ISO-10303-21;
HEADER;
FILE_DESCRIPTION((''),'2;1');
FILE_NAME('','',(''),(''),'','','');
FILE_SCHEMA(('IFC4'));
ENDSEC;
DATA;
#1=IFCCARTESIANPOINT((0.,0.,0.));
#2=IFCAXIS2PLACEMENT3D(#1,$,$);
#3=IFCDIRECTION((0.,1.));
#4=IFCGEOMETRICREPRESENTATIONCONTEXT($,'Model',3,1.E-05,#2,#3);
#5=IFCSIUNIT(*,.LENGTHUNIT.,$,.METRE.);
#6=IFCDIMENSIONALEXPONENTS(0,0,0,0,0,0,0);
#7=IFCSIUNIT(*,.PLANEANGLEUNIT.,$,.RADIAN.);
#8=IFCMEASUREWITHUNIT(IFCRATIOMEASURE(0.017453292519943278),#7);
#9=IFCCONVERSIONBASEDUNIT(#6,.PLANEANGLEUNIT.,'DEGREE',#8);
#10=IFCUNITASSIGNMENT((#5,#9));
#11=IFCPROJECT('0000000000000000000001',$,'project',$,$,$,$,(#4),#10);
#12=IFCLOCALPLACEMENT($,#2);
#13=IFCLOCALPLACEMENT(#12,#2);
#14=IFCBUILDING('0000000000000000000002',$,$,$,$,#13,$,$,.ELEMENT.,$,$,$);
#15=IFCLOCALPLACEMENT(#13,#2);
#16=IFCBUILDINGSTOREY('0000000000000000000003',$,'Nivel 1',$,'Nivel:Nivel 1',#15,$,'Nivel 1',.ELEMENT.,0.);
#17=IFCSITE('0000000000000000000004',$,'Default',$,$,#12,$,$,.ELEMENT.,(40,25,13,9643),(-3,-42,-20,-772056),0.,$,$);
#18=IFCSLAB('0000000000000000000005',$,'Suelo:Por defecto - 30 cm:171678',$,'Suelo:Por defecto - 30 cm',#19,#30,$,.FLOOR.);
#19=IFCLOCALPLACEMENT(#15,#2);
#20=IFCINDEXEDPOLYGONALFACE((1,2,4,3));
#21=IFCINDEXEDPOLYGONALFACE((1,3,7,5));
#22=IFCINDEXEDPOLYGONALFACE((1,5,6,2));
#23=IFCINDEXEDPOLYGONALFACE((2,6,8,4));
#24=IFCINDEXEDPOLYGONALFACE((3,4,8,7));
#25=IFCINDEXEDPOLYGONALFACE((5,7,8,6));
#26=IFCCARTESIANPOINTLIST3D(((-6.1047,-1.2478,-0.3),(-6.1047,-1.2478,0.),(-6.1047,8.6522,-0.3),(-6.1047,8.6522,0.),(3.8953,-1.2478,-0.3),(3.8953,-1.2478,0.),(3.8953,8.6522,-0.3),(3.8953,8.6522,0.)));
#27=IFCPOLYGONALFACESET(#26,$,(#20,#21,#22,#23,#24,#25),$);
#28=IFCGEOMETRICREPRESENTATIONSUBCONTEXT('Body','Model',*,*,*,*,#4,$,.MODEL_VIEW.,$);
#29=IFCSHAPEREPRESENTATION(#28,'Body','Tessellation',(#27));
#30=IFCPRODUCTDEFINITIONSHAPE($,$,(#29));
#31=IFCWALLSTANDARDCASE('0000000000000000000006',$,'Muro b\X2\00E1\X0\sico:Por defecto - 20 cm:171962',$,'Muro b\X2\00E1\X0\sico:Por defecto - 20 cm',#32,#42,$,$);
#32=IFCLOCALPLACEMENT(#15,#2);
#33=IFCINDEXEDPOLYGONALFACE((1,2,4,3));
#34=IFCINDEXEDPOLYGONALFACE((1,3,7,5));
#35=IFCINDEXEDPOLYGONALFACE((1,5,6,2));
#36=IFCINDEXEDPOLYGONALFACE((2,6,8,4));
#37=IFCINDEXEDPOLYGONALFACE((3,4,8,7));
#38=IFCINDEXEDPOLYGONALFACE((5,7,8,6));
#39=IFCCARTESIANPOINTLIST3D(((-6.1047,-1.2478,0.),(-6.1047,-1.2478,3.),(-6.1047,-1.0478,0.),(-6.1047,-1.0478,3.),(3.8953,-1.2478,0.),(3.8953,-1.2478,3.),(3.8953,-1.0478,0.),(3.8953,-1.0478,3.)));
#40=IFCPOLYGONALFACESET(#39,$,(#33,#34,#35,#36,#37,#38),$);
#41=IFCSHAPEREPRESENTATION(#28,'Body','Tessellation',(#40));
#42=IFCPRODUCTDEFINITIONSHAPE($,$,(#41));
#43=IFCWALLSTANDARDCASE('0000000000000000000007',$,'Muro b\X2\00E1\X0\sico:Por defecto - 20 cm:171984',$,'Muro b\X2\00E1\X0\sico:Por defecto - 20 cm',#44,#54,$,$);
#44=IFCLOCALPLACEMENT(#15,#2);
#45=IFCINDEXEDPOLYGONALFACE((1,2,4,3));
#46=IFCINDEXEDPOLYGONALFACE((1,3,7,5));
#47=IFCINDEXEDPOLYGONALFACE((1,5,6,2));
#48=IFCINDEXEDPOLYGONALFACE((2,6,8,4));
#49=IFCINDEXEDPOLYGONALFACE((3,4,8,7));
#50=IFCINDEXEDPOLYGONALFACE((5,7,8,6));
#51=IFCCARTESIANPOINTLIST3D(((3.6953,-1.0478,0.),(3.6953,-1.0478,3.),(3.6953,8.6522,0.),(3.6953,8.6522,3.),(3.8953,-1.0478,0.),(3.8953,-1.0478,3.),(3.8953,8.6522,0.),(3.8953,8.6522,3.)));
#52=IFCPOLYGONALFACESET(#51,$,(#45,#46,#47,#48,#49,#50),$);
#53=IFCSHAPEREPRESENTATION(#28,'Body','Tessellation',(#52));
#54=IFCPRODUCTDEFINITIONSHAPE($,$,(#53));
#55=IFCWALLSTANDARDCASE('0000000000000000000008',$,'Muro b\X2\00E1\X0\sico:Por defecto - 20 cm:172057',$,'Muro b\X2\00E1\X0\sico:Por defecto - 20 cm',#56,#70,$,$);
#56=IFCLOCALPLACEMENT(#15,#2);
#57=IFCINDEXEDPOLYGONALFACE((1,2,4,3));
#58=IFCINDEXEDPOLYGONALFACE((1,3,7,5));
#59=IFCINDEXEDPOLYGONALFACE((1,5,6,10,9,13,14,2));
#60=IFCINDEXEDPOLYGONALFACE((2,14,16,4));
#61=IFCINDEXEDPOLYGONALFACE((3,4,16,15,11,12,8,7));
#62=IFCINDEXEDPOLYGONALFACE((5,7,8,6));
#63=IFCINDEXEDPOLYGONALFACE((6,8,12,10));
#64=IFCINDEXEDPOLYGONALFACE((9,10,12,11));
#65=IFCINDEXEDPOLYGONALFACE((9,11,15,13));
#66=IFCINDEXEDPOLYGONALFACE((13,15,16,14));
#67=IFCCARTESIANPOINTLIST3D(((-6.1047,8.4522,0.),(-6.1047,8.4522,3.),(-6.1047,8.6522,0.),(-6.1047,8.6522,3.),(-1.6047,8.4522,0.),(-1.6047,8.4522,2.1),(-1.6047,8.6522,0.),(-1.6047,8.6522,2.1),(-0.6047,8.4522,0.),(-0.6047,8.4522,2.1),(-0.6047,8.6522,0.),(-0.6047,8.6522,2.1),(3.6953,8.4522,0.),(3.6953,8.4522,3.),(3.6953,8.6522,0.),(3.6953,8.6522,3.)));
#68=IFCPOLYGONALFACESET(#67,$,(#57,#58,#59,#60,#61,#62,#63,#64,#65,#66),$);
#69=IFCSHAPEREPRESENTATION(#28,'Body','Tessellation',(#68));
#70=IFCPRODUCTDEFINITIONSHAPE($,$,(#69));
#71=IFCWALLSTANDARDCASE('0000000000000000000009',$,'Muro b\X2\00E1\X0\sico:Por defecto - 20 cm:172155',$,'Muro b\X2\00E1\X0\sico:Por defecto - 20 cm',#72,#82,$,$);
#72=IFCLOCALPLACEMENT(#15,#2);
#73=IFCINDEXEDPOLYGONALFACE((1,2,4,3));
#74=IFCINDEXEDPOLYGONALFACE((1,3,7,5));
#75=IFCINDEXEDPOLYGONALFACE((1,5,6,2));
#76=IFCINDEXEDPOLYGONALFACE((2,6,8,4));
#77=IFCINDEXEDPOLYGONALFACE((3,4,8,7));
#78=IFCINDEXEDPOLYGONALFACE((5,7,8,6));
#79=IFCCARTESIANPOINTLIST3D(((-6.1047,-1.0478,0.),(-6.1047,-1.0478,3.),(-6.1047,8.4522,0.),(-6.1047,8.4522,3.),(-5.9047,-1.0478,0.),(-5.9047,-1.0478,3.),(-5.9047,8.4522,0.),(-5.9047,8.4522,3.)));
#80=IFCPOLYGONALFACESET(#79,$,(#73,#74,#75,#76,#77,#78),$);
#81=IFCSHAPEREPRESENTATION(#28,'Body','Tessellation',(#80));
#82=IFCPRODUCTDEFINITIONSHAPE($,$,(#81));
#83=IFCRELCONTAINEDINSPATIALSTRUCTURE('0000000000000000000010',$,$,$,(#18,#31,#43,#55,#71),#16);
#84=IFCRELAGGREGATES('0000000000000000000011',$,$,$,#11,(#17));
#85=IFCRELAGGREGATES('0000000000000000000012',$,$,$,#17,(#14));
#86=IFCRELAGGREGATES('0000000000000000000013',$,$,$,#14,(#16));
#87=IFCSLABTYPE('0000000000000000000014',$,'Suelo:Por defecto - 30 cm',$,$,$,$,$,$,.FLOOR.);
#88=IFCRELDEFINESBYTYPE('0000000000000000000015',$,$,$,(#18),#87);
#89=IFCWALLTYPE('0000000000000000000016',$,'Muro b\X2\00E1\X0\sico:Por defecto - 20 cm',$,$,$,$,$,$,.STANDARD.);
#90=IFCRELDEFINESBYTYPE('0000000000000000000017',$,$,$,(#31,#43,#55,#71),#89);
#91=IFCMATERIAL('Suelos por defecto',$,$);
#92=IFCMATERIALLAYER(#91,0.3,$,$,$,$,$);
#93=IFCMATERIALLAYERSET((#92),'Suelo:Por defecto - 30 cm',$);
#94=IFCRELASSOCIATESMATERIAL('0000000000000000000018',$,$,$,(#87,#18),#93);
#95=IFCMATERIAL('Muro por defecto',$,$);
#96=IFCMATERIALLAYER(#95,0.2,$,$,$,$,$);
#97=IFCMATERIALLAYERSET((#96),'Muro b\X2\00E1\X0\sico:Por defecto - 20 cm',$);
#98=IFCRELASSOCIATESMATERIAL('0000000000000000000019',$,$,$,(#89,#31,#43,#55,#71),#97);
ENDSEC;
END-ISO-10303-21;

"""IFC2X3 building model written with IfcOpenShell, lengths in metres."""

from ifc_helpers import new_model, entity, si_unit, converted_unit, direction, frame, frame_2d, origin, origin_2d_with_axis, place, context, subcontext, project, spatial, rectangle, extrude, material, layer, layer_set, layer_usage, type_object, element, save


model = new_model("IFC2X3")

# Units and contexts
model_context = context("Model", 3, precision=1e-05, world=origin(), true_north=direction((0.0, 1.0)))
body_context = subcontext(model_context, "Body", "Model", "MODEL_VIEW")
ifc_project = project(units=[si_unit("LENGTHUNIT", "METRE"), converted_unit("PLANEANGLEUNIT", "DEGREE", entity("IfcRatioMeasure", 0.017453292519943278), si_unit("PLANEANGLEUNIT", "RADIAN"), dimensions=[0, 0, 0, 0, 0, 0, 0])], contexts=[model_context])

# Site, building, storey
site_placement = place(None, origin())
site = spatial("IfcSite", under=ifc_project, at=site_placement, Name="Default", CompositionType="ELEMENT", RefLatitude=(40, 25, 13, 9643), RefLongitude=(-3, -42, -20, -772056), RefElevation=0.0)
building_placement = place(site_placement, origin())
building = spatial("IfcBuilding", under=site, at=building_placement, CompositionType="ELEMENT")
storey_placement = place(building_placement, origin())
storey = spatial("IfcBuildingStorey", under=building, at=storey_placement, Name="Nivel 1", ObjectType="Nivel:Nivel 1", LongName="Nivel 1", CompositionType="ELEMENT", Elevation=0.0)

# Slab
ifc_material_1 = material(Name="Suelos por defecto")
ifc_layer_1 = layer(ifc_material_1, 0.3)
ifc_layer_set_1 = layer_set([ifc_layer_1], Name="Suelo:Por defecto - 30 cm")
ifc_layer_usage_1 = layer_usage(ifc_layer_set_1, "AXIS3", "POSITIVE", 0.0)
slab_type = type_object("IfcSlabType", Name="Suelo:Por defecto - 30 cm", PredefinedType="FLOOR", material=ifc_layer_set_1)
slab_placement = place(storey_placement, origin())
element("IfcSlab", 1, at=slab_placement, inside=storey, type_object=slab_type, material=ifc_layer_usage_1, Name="Suelo:Por defecto - 30 cm:171678", ObjectType="Suelo:Por defecto - 30 cm", PredefinedType="FLOOR", context=body_context, shape_type="SweptSolid", body=[
    extrude(rectangle(XDim=9.9, YDim=10.0, at=origin_2d_with_axis()), frame((-1.1047, 3.7022, 0.0), z_axis=(0.0, 0.0, -1.0), x_axis=(0.0, 1.0, 0.0)), (0.0, 0.0, 1.0), 0.3),
])

# Walls
ifc_material_2 = material(Name="Muro por defecto")
ifc_layer_2 = layer(ifc_material_2, 0.2)
ifc_layer_set_2 = layer_set([ifc_layer_2], Name="Muro básico:Por defecto - 20 cm")
ifc_layer_usage_2 = layer_usage(ifc_layer_set_2, "AXIS2", "NEGATIVE", 0.1)
wall_type = type_object("IfcWallType", Name="Muro básico:Por defecto - 20 cm", PredefinedType="STANDARD", material=ifc_layer_set_2)
wall_1_placement = place(storey_placement, frame((-6.1047, -1.1478, 0.0)))
element("IfcWallStandardCase", 2, at=wall_1_placement, inside=storey, type_object=wall_type, material=ifc_layer_usage_2, Name="Muro básico:Por defecto - 20 cm:171962", ObjectType="Muro básico:Por defecto - 20 cm", context=body_context, shape_type="SweptSolid", body=[
    extrude(rectangle(XDim=10.0, YDim=0.2, at=frame_2d((5.0, 0.0), x_axis=(-1.0, 0.0))), origin(), (0.0, 0.0, 1.0), 3.0),
])
ifc_layer_usage_3 = layer_usage(ifc_layer_set_2, "AXIS2", "NEGATIVE", 0.1)
wall_2_placement = place(storey_placement, frame((3.7953, -1.0478, 0.0), z_axis=(0.0, 0.0, 1.0), x_axis=(0.0, 1.0, 0.0)))
element("IfcWallStandardCase", 3, at=wall_2_placement, inside=storey, type_object=wall_type, material=ifc_layer_usage_3, Name="Muro básico:Por defecto - 20 cm:171984", ObjectType="Muro básico:Por defecto - 20 cm", context=body_context, shape_type="SweptSolid", body=[
    extrude(rectangle(XDim=9.7, YDim=0.2, at=frame_2d((4.85, 0.0), x_axis=(-1.0, 0.0))), origin(), (0.0, 0.0, 1.0), 3.0),
])

# Wall, opening
ifc_layer_usage_4 = layer_usage(ifc_layer_set_2, "AXIS2", "NEGATIVE", 0.1)
wall_3_placement = place(storey_placement, frame((3.6953, 8.5522, 0.0), z_axis=(0.0, 0.0, 1.0), x_axis=(-1.0, 0.0, 0.0)))
wall_3 = element("IfcWallStandardCase", 4, at=wall_3_placement, inside=storey, type_object=wall_type, material=ifc_layer_usage_4, Name="Muro básico:Por defecto - 20 cm:172057", ObjectType="Muro básico:Por defecto - 20 cm", context=body_context, shape_type="SweptSolid", body=[
    extrude(rectangle(XDim=9.8, YDim=0.2, at=frame_2d((4.9, 0.0), x_axis=(1.0, 0.0))), origin(), (0.0, 0.0, 1.0), 3.0),
])
opening_placement = place(wall_3_placement, frame((4.3, -0.1, 0.0)))
element("IfcOpeningElement", 5, at=opening_placement, cuts=wall_3, ObjectType="Opening", context=body_context, shape_type="SweptSolid", body=[
    extrude(rectangle(XDim=2.1, YDim=1.0, at=frame_2d((1.05, 0.5), x_axis=(1.0, 0.0))), frame((0.0, 0.0, 0.0), z_axis=(0.0, 1.0, 0.0), x_axis=(0.0, 0.0, 1.0)), (0.0, 0.0, 1.0), 0.2),
])

# Wall
ifc_layer_usage_5 = layer_usage(ifc_layer_set_2, "AXIS2", "NEGATIVE", 0.1)
wall_4_placement = place(storey_placement, frame((-6.0047, 8.4522, 0.0), z_axis=(0.0, 0.0, 1.0), x_axis=(0.0, -1.0, 0.0)))
element("IfcWallStandardCase", 6, at=wall_4_placement, inside=storey, type_object=wall_type, material=ifc_layer_usage_5, Name="Muro básico:Por defecto - 20 cm:172155", ObjectType="Muro básico:Por defecto - 20 cm", context=body_context, shape_type="SweptSolid", body=[
    extrude(rectangle(XDim=9.5, YDim=0.2, at=frame_2d((4.75, 0.0), x_axis=(-1.0, 0.0))), origin(), (0.0, 0.0, 1.0), 3.0),
])

save(model, "model.ifc")
